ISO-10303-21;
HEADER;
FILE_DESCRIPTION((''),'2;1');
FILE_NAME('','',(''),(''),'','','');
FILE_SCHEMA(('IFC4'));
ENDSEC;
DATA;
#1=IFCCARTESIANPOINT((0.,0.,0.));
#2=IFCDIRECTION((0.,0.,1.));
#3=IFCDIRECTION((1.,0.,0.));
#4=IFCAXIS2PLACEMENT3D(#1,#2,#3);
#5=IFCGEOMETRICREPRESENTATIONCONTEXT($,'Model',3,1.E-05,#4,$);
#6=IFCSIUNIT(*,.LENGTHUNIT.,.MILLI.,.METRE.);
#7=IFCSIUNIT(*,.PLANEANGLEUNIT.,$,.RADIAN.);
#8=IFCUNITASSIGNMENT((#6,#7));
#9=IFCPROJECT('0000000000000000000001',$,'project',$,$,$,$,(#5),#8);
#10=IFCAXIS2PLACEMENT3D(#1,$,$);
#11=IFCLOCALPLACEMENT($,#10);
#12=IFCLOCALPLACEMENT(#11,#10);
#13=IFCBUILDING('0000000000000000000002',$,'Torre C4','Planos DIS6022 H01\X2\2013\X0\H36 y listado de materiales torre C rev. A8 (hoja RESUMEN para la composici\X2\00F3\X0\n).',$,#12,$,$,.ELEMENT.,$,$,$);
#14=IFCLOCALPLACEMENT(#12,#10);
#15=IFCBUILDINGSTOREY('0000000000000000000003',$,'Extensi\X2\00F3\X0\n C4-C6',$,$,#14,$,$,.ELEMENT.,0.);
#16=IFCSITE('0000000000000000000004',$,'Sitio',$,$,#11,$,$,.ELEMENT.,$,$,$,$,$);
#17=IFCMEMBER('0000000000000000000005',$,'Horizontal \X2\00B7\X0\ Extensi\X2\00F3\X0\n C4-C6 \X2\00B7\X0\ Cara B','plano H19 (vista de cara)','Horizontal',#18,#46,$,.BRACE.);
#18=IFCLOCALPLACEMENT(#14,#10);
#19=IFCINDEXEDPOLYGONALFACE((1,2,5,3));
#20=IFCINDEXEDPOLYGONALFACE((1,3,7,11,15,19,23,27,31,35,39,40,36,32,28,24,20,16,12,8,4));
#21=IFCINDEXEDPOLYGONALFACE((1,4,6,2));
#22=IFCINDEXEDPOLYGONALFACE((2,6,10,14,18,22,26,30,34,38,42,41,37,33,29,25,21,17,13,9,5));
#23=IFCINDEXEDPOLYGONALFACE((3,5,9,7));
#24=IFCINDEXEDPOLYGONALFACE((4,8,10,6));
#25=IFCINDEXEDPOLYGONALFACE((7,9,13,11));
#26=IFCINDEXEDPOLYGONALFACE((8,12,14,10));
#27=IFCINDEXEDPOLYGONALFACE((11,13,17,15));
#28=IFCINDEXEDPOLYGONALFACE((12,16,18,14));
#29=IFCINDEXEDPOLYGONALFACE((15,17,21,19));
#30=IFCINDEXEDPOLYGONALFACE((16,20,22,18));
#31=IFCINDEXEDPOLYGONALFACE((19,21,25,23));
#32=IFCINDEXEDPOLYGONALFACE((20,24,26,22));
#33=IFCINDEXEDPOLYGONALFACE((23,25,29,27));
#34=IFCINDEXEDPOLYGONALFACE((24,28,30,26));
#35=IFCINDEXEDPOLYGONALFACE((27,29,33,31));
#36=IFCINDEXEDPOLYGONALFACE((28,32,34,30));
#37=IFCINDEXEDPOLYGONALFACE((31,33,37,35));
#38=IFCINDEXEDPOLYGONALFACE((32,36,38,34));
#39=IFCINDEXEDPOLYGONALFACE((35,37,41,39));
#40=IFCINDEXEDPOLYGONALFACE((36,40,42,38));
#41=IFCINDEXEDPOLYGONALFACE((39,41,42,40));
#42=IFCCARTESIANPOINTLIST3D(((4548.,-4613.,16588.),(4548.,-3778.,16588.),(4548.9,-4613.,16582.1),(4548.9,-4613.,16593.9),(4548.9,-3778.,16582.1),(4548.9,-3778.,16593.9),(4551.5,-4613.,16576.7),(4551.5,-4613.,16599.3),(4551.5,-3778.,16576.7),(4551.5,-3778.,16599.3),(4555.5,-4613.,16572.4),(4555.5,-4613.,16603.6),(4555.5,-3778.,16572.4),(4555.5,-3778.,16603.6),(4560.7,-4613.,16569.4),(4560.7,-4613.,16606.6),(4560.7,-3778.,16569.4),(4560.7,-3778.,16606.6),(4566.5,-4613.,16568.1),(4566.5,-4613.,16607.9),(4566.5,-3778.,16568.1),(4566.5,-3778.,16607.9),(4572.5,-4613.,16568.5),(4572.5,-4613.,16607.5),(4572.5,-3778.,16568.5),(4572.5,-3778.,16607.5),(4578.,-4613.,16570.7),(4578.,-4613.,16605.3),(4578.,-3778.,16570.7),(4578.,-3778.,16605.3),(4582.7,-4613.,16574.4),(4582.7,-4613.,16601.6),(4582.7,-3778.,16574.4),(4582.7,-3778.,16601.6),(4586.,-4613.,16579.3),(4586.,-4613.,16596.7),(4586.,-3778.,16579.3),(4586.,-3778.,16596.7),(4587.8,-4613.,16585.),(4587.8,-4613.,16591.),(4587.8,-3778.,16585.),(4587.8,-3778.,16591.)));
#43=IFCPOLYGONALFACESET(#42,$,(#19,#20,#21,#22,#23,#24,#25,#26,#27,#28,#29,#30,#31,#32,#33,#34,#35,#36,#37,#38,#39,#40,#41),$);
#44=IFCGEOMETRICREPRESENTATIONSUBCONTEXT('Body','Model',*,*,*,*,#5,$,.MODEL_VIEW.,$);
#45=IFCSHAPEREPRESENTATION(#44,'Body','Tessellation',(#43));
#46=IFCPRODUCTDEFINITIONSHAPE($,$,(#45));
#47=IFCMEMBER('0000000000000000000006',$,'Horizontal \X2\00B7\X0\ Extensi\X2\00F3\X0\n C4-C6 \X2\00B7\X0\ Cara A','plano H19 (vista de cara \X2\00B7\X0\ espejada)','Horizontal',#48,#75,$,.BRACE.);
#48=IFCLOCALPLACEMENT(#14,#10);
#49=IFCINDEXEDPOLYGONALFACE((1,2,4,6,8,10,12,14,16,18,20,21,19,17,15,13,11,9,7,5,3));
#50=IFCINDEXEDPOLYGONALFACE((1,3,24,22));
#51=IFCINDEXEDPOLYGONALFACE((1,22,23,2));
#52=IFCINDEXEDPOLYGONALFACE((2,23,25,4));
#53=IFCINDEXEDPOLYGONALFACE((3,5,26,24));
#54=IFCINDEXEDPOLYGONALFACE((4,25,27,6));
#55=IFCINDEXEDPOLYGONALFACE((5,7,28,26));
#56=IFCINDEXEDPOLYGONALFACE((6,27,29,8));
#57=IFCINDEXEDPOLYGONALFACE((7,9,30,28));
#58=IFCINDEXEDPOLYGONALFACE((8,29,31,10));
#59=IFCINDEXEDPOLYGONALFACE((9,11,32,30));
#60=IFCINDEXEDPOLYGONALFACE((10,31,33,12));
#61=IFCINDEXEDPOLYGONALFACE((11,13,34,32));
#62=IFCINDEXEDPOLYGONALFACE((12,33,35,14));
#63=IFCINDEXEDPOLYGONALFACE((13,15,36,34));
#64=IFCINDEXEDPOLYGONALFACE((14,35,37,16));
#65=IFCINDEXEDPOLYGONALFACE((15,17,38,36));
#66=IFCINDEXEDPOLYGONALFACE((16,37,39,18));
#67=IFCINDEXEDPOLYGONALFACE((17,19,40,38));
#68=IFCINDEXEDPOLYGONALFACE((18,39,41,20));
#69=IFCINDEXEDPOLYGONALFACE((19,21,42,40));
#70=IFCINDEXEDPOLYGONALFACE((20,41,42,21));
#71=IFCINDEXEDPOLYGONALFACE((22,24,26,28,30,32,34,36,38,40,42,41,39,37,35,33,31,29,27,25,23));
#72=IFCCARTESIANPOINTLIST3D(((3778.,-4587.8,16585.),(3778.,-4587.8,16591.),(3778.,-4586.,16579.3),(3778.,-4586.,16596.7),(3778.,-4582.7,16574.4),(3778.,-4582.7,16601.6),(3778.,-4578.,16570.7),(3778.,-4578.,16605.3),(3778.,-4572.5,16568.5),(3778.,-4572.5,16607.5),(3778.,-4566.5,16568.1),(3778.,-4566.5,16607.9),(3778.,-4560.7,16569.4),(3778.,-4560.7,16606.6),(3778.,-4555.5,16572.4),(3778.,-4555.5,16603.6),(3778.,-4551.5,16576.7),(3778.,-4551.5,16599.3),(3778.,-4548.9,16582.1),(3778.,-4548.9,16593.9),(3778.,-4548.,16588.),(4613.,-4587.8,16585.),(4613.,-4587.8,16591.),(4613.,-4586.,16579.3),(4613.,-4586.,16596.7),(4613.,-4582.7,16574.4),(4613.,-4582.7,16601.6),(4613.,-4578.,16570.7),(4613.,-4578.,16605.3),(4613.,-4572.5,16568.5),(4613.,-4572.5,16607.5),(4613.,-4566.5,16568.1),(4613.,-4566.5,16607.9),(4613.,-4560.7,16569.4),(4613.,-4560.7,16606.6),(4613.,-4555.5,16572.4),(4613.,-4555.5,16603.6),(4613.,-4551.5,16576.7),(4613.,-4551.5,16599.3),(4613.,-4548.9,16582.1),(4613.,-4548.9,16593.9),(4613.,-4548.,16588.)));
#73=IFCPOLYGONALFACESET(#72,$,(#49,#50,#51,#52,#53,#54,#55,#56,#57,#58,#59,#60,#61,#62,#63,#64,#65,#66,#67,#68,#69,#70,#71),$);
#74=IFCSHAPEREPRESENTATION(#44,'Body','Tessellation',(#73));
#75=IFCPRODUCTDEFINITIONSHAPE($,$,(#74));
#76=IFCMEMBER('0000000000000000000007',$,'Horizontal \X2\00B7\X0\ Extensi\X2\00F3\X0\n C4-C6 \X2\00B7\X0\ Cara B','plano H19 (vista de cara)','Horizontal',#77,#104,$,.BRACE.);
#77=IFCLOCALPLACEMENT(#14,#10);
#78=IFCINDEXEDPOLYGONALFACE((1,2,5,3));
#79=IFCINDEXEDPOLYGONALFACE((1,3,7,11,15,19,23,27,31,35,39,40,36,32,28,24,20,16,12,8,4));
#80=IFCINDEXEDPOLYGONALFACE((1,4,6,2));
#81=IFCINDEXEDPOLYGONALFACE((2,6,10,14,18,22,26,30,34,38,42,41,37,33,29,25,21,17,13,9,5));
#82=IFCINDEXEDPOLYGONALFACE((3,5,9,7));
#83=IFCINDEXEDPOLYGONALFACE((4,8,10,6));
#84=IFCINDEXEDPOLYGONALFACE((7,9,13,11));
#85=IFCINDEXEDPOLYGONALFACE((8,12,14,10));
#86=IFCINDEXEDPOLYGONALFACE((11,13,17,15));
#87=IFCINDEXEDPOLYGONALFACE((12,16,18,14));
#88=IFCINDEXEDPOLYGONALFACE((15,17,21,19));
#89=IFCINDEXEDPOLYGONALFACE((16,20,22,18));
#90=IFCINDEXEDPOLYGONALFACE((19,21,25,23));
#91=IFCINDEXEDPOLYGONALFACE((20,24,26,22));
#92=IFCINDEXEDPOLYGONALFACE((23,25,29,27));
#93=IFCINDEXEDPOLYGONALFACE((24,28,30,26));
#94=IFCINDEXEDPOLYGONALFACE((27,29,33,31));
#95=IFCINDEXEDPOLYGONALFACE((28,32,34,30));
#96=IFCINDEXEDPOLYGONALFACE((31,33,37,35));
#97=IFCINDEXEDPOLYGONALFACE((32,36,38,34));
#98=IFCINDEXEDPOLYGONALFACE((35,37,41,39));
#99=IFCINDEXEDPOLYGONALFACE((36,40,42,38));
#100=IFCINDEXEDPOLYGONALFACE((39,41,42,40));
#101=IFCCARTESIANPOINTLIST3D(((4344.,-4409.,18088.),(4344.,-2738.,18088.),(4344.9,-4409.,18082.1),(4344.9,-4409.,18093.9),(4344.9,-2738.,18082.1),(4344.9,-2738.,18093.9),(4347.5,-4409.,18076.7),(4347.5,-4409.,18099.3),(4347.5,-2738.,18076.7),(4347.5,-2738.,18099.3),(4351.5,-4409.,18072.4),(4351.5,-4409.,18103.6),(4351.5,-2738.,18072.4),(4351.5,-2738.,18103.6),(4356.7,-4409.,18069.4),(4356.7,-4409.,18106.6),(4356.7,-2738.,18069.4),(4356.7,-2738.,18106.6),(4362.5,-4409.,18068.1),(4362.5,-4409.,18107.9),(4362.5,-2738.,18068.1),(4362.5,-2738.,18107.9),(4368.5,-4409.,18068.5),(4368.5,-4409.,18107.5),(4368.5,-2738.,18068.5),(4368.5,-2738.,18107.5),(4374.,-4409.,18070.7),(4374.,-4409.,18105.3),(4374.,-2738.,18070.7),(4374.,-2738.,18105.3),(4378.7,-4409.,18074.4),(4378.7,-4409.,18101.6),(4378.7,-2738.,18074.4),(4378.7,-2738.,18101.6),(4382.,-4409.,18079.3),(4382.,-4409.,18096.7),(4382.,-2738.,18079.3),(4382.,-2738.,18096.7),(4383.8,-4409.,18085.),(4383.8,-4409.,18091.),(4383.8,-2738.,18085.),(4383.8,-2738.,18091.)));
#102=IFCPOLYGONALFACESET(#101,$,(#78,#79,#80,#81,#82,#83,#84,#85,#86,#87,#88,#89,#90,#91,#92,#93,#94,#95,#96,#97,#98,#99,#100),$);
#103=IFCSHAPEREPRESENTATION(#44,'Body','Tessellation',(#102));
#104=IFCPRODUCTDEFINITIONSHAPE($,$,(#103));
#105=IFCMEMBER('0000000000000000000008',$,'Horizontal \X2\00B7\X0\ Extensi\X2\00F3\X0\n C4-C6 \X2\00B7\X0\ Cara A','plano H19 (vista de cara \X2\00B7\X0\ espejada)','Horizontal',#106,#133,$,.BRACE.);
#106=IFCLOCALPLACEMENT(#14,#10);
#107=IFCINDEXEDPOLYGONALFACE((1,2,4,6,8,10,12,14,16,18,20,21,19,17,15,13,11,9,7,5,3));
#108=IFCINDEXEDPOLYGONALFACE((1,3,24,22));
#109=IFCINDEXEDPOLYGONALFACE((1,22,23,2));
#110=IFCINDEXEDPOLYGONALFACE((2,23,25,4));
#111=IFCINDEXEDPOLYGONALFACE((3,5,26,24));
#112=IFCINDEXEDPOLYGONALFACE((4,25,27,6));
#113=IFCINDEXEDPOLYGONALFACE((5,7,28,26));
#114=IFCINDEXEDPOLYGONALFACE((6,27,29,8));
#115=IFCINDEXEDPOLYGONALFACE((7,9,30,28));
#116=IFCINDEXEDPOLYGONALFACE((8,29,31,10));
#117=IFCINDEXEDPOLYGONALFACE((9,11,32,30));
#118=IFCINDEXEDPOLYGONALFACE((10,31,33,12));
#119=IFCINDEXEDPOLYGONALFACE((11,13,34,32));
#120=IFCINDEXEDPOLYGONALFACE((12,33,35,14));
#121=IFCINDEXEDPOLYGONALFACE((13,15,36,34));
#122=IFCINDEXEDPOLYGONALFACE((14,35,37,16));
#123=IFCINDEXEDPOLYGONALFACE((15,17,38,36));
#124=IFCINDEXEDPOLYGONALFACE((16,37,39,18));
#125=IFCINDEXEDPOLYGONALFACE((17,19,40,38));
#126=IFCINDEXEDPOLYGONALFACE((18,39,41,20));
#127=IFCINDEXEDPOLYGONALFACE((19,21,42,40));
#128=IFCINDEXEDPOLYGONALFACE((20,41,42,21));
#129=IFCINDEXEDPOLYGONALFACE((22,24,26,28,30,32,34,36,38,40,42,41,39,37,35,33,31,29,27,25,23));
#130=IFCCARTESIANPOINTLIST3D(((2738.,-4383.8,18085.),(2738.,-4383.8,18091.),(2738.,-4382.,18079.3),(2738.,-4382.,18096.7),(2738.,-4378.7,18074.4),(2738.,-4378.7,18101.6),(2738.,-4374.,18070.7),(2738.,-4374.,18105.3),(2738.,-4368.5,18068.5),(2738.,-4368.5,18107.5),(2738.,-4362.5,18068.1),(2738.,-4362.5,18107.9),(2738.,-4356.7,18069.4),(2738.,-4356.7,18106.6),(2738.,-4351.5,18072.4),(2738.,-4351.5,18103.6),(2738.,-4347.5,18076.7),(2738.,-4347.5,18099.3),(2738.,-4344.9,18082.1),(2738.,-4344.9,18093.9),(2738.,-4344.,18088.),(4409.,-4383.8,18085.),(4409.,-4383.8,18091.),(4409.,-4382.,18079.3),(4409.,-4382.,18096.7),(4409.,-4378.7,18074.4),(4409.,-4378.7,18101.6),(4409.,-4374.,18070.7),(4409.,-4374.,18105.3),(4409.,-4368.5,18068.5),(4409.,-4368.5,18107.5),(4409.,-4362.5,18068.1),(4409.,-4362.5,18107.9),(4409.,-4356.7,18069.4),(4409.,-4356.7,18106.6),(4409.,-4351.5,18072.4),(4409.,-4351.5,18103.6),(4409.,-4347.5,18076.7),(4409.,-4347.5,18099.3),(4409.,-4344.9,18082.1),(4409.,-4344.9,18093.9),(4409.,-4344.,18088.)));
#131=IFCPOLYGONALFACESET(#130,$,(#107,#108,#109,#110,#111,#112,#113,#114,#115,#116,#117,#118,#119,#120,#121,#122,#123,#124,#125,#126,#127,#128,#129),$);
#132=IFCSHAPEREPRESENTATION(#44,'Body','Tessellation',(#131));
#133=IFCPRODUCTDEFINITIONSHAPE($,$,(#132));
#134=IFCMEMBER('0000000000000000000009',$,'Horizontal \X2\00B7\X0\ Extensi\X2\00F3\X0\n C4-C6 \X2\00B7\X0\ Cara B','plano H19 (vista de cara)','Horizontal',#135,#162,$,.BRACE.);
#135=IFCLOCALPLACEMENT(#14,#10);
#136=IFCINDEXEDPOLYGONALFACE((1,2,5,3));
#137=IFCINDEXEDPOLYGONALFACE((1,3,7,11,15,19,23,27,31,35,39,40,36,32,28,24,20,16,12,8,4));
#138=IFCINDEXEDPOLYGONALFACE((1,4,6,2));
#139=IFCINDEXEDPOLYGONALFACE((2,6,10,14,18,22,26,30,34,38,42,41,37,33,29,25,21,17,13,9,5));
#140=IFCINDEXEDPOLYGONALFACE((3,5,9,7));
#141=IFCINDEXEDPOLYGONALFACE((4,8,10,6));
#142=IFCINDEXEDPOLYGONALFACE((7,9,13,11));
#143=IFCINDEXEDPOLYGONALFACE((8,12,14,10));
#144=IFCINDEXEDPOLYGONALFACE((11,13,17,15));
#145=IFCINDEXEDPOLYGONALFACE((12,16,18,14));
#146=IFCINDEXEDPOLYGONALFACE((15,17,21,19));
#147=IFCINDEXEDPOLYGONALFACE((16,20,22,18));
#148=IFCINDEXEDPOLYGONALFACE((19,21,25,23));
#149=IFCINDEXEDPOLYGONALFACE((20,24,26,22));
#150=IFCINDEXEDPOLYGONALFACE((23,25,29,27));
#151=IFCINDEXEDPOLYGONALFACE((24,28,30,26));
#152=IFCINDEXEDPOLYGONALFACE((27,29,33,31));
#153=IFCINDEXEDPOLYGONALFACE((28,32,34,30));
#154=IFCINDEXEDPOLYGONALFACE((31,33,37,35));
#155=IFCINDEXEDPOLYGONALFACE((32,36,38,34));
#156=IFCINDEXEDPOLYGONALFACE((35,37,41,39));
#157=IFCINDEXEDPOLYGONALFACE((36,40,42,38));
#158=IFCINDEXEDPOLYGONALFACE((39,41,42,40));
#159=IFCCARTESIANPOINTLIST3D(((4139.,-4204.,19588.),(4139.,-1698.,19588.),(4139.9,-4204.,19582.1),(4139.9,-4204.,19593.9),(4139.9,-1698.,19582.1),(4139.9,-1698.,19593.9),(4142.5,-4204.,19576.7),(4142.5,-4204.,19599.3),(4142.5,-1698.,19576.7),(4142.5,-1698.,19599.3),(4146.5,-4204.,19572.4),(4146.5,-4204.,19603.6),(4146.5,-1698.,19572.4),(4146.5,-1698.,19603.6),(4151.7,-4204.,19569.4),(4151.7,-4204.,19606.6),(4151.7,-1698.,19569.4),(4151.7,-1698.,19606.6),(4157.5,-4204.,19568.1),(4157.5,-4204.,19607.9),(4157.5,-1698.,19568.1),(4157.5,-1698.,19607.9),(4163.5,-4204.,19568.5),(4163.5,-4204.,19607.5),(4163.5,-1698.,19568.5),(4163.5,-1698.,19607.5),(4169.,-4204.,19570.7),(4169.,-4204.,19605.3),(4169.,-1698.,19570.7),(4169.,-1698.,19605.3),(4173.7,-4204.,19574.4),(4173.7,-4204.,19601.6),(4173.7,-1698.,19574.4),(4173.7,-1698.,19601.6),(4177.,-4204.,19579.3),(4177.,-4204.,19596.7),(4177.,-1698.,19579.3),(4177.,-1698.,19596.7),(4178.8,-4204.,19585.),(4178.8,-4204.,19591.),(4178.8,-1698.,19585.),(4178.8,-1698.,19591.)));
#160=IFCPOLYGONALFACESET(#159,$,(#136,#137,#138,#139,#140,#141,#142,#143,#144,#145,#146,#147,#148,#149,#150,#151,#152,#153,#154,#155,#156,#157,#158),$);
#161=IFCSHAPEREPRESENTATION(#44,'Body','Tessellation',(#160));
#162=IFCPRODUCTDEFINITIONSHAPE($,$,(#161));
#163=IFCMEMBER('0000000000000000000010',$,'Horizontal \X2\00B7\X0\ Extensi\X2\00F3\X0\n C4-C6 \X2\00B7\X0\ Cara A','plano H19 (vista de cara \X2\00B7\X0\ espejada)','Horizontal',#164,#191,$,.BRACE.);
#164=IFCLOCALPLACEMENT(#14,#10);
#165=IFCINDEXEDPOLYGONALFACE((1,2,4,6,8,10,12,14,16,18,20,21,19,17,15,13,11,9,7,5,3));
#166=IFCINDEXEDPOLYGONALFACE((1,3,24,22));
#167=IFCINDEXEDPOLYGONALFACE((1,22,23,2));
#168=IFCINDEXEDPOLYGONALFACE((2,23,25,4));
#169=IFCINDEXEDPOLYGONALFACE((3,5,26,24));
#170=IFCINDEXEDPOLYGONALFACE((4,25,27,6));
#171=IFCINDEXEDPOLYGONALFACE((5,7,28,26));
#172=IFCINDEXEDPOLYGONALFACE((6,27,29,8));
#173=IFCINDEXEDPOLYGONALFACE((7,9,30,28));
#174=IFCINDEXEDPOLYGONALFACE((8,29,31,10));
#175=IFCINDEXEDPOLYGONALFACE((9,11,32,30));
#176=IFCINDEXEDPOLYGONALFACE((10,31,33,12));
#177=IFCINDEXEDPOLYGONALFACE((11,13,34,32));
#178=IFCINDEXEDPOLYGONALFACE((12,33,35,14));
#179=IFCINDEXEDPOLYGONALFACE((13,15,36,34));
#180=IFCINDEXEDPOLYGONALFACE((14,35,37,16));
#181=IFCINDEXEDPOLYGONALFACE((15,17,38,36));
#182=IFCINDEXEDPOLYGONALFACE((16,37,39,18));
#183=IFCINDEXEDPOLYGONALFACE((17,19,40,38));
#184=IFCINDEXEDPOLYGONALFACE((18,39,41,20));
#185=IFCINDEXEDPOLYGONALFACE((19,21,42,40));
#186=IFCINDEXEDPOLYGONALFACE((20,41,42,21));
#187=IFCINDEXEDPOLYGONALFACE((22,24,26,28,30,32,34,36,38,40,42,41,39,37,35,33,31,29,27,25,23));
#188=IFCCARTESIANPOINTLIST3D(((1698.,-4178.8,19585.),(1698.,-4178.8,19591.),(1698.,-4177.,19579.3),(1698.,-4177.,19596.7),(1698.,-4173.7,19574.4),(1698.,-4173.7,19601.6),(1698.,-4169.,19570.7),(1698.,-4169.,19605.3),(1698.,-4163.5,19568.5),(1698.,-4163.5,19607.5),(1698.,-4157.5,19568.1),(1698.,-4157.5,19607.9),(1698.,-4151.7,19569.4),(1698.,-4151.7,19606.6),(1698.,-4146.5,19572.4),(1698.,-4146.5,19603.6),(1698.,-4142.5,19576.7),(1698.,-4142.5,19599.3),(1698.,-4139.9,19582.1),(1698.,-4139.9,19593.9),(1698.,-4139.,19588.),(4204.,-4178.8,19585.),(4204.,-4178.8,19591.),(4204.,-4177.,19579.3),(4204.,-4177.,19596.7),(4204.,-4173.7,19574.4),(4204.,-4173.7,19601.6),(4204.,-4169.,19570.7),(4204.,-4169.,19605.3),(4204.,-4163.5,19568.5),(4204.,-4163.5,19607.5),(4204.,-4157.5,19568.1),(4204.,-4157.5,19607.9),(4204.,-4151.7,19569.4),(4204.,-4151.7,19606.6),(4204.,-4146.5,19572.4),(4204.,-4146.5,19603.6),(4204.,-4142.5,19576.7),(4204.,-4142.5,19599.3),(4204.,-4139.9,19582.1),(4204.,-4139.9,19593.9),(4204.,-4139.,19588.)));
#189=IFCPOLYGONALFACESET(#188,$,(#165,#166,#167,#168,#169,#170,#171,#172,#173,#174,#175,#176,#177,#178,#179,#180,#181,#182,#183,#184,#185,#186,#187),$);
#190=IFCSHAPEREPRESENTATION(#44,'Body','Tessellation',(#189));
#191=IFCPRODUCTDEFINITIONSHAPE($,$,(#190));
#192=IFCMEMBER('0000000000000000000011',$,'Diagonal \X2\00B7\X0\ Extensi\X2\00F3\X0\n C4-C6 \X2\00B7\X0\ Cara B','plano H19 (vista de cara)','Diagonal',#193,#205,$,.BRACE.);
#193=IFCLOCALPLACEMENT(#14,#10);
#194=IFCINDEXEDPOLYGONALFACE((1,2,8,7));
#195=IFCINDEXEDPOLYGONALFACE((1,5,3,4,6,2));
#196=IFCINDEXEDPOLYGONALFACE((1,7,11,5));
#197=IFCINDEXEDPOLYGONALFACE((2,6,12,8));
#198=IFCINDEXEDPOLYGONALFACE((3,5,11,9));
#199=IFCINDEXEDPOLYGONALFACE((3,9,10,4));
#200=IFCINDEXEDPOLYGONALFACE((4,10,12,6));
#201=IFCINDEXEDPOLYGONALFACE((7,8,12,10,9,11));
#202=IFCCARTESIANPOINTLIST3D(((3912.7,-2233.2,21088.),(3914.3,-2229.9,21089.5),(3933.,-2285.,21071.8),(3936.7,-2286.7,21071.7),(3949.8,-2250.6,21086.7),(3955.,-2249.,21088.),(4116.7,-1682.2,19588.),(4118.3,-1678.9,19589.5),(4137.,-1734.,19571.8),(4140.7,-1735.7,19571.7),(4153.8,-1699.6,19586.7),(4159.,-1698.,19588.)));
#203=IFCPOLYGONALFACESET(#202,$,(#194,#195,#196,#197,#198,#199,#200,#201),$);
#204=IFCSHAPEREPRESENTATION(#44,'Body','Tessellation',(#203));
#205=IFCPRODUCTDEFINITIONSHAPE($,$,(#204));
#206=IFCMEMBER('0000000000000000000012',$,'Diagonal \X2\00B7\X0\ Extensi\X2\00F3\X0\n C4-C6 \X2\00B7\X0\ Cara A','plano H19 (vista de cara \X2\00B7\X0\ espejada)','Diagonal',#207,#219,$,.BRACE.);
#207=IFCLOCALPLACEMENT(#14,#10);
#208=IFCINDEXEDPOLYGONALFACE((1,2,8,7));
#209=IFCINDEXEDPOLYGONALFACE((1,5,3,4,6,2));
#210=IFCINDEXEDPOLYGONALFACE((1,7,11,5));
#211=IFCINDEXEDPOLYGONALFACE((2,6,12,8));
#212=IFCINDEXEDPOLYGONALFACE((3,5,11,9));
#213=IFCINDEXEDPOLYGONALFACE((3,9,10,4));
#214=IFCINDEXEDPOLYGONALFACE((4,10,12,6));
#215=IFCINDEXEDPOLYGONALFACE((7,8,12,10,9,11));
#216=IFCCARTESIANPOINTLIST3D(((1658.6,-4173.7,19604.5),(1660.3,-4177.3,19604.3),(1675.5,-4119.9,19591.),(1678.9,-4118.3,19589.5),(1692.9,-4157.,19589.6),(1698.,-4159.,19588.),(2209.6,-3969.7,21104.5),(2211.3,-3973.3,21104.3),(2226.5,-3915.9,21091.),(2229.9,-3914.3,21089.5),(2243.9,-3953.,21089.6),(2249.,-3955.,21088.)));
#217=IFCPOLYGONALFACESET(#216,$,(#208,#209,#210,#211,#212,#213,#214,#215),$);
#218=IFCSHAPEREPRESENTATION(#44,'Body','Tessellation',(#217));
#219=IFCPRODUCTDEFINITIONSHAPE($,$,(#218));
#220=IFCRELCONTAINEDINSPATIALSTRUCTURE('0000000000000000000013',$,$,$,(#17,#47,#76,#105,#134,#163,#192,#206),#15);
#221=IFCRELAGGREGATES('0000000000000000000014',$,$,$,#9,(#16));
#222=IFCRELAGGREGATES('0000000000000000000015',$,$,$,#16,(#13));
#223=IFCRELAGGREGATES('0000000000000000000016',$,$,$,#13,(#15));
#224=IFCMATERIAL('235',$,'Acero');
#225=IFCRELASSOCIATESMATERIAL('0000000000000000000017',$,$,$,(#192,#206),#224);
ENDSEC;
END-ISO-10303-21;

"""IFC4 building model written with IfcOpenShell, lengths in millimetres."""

from ifc_helpers import new_model, si_unit, frame, frame_2d, origin, origin_with_axes, place, context, subcontext, project, spatial, circle, l_section, extrude, material, element, save


model = new_model("IFC4")

# Units and contexts
model_context = context("Model", 3, precision=1e-05, world=origin_with_axes())
body_context = subcontext(model_context, "Body", "Model", "MODEL_VIEW")
ifc_project = project(units=[si_unit("LENGTHUNIT", "METRE", prefix="MILLI"), si_unit("PLANEANGLEUNIT", "RADIAN")], contexts=[model_context])

# Site, building, storey
site_placement = place(None, origin())
site = spatial("IfcSite", under=ifc_project, at=site_placement, Name="Sitio", CompositionType="ELEMENT")
building_placement = place(site_placement, origin())
building = spatial("IfcBuilding", under=site, at=building_placement, Name="Torre C4", Description="Planos DIS6022 H01–H36 y listado de materiales torre C rev. A8 (hoja RESUMEN para la composición).", CompositionType="ELEMENT")
storey_placement = place(building_placement, origin())
storey = spatial("IfcBuildingStorey", under=building, at=storey_placement, Name="Extensión C4-C6", CompositionType="ELEMENT", Elevation=0.0)

# Members
ifc_material = material(Name="235", Category="Acero")
for number, where, z_axis, x_axis, name, description in (
    (1, (4568.0, -3778.0, 16588.0), (0.0, -1.0, 0.0), (-1.0, 0.0, 0.0), "Horizontal · Extensión C4-C6 · Cara B", "plano H19 (vista de cara)"),
    (2, (3778.0, -4568.0, 16588.0), (1.0, 0.0, 0.0), (0.0, 1.0, 0.0), "Horizontal · Extensión C4-C6 · Cara A", "plano H19 (vista de cara · espejada)"),
):
    element("IfcMember", number, at=place(storey_placement, frame(where, z_axis=z_axis, x_axis=x_axis)), inside=storey, Name=name, Description=description, ObjectType="Horizontal", PredefinedType="BRACE", context=body_context, shape_type="SweptSolid", body=[
        extrude(circle(Radius=20.0), None, (0.0, 0.0, 1.0), 835.0),
    ])
for number, where, z_axis, x_axis, name, description in (
    (3, (4364.0, -2738.0, 18088.0), (0.0, -1.0, 0.0), (-1.0, 0.0, 0.0), "Horizontal · Extensión C4-C6 · Cara B", "plano H19 (vista de cara)"),
    (4, (2738.0, -4364.0, 18088.0), (1.0, 0.0, 0.0), (0.0, 1.0, 0.0), "Horizontal · Extensión C4-C6 · Cara A", "plano H19 (vista de cara · espejada)"),
):
    element("IfcMember", number, at=place(storey_placement, frame(where, z_axis=z_axis, x_axis=x_axis)), inside=storey, Name=name, Description=description, ObjectType="Horizontal", PredefinedType="BRACE", context=body_context, shape_type="SweptSolid", body=[
        extrude(circle(Radius=20.0), None, (0.0, 0.0, 1.0), 1671.0),
    ])
for number, where, z_axis, x_axis, name, description in (
    (5, (4159.0, -1698.0, 19588.0), (0.0, -1.0, 0.0), (-1.0, 0.0, 0.0), "Horizontal · Extensión C4-C6 · Cara B", "plano H19 (vista de cara)"),
    (6, (1698.0, -4159.0, 19588.0), (1.0, 0.0, 0.0), (0.0, 1.0, 0.0), "Horizontal · Extensión C4-C6 · Cara A", "plano H19 (vista de cara · espejada)"),
):
    element("IfcMember", number, at=place(storey_placement, frame(where, z_axis=z_axis, x_axis=x_axis)), inside=storey, Name=name, Description=description, ObjectType="Horizontal", PredefinedType="BRACE", context=body_context, shape_type="SweptSolid", body=[
        extrude(circle(Radius=20.0), None, (0.0, 0.0, 1.0), 2506.0),
    ])
for number, where, z_axis, x_axis, name, description in (
    (7, (4159.0, -1698.0, 19588.0), (-0.126632, -0.34203, 0.931117), (-0.904354, 0.425481, 0.033301), "Diagonal · Extensión C4-C6 · Cara B", "plano H19 (vista de cara)"),
    (8, (1698.0, -4159.0, 19588.0), (0.34203, 0.126632, 0.931117), (-0.425481, 0.904354, 0.033301), "Diagonal · Extensión C4-C6 · Cara A", "plano H19 (vista de cara · espejada)"),
):
    element("IfcMember", number, at=place(storey_placement, frame(where, z_axis=z_axis, x_axis=x_axis)), inside=storey, material=ifc_material, Name=name, Description=description, ObjectType="Diagonal", PredefinedType="BRACE", context=body_context, shape_type="SweptSolid", body=[
        extrude(l_section(Depth=45.0, Width=45.0, Thickness=4.0, at=frame_2d((22.5, 22.5))), None, (0.0, 0.0, 1.0), 1611.0),
    ])

save(model, "model.ifc")
